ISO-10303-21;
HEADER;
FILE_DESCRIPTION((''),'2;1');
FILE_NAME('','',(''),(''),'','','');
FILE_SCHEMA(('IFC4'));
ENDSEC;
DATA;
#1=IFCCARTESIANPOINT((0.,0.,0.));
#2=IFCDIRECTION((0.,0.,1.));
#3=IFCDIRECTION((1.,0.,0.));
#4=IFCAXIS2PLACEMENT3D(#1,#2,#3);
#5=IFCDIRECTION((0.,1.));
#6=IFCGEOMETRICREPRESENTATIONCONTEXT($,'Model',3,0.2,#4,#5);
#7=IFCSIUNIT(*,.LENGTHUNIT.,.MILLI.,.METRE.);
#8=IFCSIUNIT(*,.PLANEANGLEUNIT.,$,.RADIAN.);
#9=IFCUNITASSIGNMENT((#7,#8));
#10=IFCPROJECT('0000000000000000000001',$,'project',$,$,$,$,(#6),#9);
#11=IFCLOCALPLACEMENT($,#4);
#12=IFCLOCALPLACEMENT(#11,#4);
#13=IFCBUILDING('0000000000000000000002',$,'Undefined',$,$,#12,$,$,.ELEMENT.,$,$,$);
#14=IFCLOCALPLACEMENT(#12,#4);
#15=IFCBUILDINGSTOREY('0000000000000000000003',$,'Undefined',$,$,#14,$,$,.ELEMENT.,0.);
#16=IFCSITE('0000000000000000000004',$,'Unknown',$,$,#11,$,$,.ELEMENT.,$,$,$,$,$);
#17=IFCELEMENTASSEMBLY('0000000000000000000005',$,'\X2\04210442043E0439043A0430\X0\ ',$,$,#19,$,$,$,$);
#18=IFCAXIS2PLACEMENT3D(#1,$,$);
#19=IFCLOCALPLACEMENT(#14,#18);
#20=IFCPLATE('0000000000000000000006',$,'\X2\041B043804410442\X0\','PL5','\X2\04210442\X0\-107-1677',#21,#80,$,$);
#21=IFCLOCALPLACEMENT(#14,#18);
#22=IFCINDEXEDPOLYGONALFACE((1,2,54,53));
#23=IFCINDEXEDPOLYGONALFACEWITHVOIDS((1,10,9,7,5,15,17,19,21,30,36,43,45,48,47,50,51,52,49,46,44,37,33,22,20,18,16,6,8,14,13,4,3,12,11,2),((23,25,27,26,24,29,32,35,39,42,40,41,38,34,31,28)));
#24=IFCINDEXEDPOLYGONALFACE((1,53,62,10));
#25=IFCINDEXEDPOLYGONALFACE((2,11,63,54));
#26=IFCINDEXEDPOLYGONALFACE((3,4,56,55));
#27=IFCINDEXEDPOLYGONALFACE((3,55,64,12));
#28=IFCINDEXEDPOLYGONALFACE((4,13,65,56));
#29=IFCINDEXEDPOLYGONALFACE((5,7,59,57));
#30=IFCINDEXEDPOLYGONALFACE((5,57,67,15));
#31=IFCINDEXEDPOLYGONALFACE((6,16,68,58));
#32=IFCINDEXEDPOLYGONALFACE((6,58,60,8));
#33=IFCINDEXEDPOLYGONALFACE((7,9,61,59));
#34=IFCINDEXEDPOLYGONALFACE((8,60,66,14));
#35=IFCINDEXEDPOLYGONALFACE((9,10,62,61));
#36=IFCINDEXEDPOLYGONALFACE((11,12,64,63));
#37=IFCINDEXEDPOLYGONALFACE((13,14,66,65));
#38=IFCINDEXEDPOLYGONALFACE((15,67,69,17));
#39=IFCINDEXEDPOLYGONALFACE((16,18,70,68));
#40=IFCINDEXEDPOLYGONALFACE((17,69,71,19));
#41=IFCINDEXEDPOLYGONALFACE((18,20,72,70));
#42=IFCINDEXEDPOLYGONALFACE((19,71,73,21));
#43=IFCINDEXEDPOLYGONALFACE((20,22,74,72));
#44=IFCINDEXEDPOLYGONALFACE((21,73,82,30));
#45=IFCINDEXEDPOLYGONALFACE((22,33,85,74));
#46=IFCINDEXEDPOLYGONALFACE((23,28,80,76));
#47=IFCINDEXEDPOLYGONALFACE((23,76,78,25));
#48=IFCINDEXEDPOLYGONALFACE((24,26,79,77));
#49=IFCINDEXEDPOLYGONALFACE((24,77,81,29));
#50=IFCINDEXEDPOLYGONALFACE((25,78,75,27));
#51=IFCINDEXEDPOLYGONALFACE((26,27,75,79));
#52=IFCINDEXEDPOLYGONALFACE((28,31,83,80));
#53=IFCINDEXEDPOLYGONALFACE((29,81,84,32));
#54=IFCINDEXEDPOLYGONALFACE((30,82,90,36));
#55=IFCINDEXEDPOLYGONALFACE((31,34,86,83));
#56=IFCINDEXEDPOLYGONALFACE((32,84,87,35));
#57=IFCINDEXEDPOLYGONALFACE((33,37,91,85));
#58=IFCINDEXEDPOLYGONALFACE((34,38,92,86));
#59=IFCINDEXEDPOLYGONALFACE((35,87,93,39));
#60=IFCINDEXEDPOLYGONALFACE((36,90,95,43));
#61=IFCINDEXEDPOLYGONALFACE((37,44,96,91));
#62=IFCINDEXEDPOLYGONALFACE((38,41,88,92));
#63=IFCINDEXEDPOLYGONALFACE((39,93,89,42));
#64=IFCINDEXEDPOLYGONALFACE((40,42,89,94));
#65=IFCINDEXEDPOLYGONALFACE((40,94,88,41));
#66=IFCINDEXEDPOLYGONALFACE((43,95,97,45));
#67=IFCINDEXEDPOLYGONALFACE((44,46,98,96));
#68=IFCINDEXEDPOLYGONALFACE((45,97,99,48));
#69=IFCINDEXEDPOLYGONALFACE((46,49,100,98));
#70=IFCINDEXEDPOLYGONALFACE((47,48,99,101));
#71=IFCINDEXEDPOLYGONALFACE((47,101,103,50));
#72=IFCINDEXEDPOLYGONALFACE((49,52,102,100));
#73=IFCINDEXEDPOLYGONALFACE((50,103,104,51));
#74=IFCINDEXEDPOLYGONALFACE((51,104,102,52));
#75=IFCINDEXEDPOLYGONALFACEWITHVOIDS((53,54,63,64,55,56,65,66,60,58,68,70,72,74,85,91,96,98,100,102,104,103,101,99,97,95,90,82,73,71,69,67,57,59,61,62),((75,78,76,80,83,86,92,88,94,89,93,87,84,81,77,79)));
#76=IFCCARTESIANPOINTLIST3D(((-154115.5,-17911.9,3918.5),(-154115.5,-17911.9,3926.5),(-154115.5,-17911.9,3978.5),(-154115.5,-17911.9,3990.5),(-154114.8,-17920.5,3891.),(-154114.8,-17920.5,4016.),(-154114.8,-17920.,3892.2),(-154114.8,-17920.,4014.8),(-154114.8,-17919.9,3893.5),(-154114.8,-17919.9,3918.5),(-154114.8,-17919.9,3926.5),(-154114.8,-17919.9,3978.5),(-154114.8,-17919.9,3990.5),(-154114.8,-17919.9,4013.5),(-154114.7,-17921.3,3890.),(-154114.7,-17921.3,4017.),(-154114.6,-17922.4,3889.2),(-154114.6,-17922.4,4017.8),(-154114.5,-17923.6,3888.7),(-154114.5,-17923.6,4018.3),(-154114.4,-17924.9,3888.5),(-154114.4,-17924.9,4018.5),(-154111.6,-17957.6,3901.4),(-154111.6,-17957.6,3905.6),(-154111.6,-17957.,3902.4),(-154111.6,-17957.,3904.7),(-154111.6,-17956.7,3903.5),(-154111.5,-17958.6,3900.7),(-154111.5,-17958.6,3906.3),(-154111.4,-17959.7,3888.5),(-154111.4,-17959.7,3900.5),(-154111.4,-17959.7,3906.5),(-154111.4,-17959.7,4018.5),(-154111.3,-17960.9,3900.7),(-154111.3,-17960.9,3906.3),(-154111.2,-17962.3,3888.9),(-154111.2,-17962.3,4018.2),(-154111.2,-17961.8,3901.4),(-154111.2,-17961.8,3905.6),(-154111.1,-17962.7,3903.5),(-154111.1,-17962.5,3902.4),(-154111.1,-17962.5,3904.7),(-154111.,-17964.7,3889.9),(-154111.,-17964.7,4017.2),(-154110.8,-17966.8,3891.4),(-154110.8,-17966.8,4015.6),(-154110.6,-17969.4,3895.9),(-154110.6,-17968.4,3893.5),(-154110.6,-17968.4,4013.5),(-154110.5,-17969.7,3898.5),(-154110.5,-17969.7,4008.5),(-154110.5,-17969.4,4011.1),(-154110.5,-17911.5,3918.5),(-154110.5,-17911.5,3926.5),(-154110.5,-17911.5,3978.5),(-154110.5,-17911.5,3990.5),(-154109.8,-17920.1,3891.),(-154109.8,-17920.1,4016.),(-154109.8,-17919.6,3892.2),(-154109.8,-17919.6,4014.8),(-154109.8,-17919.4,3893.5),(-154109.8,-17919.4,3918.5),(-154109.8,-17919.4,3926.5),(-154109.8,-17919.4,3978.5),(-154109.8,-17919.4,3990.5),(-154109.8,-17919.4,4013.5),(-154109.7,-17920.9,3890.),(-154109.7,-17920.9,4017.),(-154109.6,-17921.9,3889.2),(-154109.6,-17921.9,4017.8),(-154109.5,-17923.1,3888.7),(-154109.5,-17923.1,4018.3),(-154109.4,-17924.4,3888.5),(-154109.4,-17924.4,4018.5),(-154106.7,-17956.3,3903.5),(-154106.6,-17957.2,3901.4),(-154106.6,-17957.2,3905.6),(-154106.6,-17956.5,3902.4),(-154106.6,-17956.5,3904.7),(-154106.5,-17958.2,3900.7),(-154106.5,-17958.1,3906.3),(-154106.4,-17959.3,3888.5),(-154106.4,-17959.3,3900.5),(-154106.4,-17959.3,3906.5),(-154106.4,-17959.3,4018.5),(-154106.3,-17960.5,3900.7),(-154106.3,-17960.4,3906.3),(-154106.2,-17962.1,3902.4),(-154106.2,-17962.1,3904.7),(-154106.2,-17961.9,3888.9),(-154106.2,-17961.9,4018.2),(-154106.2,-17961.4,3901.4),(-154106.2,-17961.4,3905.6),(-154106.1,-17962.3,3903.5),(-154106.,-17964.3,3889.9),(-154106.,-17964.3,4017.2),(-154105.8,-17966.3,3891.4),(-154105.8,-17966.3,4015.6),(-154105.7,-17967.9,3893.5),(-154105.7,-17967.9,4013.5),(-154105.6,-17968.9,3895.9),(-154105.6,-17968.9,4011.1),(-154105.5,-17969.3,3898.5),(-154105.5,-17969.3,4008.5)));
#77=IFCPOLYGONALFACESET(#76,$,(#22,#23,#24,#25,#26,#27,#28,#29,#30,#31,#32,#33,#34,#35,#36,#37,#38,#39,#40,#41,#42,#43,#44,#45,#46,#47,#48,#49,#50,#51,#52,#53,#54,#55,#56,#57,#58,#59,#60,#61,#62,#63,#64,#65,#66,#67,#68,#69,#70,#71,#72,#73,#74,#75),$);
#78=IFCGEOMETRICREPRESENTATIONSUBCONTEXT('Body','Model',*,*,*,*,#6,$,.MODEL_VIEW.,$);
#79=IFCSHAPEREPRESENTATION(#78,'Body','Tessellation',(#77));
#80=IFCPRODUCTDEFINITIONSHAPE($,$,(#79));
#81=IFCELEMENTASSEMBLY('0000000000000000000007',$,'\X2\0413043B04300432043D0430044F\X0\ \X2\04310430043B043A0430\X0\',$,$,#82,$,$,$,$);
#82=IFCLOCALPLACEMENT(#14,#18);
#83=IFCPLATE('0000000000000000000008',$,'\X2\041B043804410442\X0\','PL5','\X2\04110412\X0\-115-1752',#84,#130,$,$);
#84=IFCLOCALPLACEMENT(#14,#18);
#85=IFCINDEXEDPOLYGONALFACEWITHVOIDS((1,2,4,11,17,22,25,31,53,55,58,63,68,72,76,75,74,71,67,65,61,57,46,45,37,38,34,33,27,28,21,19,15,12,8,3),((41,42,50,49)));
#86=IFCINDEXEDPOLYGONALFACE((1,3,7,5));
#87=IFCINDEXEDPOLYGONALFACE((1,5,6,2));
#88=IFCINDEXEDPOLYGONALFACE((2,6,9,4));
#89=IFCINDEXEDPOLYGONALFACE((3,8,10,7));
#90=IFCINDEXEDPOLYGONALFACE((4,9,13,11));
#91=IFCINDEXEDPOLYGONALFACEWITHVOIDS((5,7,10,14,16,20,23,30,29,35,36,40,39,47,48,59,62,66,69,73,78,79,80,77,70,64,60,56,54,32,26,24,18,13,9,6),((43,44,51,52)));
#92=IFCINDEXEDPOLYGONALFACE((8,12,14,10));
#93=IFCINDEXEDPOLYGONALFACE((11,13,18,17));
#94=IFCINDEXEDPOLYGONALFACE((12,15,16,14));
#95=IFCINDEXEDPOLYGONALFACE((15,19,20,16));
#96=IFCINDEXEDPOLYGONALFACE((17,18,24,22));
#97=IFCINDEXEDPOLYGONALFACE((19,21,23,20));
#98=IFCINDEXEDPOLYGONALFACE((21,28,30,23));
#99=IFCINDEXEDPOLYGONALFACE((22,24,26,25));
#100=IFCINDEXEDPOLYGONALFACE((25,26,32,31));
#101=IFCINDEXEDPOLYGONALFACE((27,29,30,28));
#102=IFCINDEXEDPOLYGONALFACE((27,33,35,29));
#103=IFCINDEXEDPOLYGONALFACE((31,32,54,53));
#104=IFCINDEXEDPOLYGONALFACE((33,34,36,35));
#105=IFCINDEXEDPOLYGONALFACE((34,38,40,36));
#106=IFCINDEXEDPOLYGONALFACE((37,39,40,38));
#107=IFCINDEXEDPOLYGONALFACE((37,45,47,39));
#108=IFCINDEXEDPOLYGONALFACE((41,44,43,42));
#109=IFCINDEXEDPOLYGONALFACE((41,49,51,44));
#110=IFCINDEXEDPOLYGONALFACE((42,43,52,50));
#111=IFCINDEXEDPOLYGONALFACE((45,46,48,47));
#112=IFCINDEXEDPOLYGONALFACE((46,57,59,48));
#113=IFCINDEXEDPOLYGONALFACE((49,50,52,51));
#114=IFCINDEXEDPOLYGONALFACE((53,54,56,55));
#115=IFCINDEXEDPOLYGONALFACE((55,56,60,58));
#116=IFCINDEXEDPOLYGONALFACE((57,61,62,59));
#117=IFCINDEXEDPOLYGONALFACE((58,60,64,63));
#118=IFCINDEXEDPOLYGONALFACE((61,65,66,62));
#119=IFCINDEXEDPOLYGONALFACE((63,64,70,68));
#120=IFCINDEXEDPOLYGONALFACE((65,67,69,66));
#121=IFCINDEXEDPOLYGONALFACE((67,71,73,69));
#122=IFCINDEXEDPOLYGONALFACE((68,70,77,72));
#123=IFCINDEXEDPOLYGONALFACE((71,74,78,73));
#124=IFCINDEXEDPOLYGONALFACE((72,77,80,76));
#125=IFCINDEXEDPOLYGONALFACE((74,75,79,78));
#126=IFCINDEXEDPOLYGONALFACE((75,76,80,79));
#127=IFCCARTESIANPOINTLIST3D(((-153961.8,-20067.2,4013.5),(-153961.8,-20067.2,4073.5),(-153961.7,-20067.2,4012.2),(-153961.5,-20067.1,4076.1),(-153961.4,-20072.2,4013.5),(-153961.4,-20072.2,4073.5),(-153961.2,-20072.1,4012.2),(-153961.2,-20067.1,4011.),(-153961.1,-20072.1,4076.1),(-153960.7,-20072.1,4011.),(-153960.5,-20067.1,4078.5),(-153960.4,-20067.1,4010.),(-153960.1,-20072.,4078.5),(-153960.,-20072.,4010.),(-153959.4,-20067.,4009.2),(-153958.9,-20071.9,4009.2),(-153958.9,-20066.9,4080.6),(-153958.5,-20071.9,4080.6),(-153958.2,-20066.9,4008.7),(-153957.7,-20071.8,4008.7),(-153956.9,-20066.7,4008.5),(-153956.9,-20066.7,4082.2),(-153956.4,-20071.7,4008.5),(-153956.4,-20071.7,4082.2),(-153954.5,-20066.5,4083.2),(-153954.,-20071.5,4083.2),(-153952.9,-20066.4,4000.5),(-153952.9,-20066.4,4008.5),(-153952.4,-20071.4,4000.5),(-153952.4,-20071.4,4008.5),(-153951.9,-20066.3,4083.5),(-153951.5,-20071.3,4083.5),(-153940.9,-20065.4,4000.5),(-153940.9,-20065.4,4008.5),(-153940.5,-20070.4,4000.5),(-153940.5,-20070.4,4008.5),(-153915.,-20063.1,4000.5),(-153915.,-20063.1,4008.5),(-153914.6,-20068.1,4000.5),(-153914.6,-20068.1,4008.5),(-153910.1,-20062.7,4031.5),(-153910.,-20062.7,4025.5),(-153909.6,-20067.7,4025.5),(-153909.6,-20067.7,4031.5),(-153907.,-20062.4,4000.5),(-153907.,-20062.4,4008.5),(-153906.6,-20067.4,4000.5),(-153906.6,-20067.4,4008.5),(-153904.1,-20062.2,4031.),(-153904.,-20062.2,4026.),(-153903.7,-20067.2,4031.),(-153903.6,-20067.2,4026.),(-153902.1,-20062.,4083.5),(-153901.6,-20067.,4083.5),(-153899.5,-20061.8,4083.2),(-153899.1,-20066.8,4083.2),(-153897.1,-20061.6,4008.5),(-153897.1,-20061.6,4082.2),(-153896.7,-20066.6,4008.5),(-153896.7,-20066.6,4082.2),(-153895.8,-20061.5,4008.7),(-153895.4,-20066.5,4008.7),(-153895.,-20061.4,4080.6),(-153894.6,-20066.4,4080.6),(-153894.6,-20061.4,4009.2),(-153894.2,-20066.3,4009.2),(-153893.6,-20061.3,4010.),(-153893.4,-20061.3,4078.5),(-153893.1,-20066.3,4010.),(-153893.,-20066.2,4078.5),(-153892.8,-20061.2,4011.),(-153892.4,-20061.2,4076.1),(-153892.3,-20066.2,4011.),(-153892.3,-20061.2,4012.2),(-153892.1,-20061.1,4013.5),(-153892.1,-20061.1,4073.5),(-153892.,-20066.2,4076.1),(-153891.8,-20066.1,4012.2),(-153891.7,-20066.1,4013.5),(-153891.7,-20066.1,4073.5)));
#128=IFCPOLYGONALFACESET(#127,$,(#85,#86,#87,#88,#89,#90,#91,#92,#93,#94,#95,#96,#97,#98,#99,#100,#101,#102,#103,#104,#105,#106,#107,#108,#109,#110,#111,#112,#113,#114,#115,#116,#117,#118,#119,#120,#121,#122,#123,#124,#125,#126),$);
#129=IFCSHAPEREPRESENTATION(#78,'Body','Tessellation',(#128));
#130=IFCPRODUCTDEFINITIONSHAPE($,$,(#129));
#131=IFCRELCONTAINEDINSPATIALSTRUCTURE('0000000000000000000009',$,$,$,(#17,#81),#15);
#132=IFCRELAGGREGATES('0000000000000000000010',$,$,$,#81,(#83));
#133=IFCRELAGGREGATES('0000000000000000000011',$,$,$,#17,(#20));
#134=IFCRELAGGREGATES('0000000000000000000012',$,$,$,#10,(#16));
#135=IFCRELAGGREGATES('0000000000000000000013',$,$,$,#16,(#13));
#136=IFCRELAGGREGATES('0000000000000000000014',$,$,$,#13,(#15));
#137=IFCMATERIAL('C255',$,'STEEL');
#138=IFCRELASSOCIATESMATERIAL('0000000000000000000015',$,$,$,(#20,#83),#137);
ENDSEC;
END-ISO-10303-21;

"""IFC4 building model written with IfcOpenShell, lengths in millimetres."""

from ifc_helpers import new_model, si_unit, direction, frame, origin_with_axes, place, context, subcontext, project, spatial, line, arc, indexed_curve, outline, extrude, material, element, aggregate, save


model = new_model("IFC4")

# Units and contexts
model_context = context("Model", 3, precision=0.2, world=origin_with_axes(), true_north=direction((0.0, 1.0)))
body_context = subcontext(model_context, "Body", "Model", "MODEL_VIEW")
ifc_project = project(units=[si_unit("LENGTHUNIT", "METRE", prefix="MILLI"), si_unit("PLANEANGLEUNIT", "RADIAN")], contexts=[model_context])

# Site, building, storey
site_placement = place(None, origin_with_axes())
site = spatial("IfcSite", under=ifc_project, at=site_placement, Name="Unknown", CompositionType="ELEMENT")
building_placement = place(site_placement, origin_with_axes())
building = spatial("IfcBuilding", under=site, at=building_placement, Name="Undefined", CompositionType="ELEMENT")
storey_placement = place(building_placement, origin_with_axes())
storey = spatial("IfcBuildingStorey", under=building, at=storey_placement, Name="Undefined", CompositionType="ELEMENT", Elevation=0.0)

# Shared definitions
ifc_material_1 = material(Name="C255", Category="STEEL")

# Element assemblies, plates, voiding features
assembly_1_placement = place(storey_placement, frame((-154120.8, -17880.2, 4823.9), z_axis=(0.086114, -0.996285, 0.0), x_axis=(0.0, 0.0, -1.0)))
assembly_1 = element("IfcElementAssembly", 1, at=assembly_1_placement, inside=storey, Name="Стойка ")
plate_1_placement = place(assembly_1_placement, frame((935.3, 5.0, 90.0), z_axis=(-0.000024, -1.0, 0.0), x_axis=(-1.0, 0.000024, 0.0)))
plate_1 = element("IfcPlate", 2, at=plate_1_placement, material=ifc_material_1, Name="Лист", Description="PL5", ObjectType="Ст-107-1677", context=body_context, shape_type="SolidModel", body=[
    extrude(outline(indexed_curve([(0.0, 10.0), (2.9, 2.9), (10.0, 0.0), (120.0, 0.0), (127.1, 2.9), (130.0, 10.0), (130.0, 45.0), (128.5, 48.5), (125.0, 50.0), (102.0, 50.0), (102.0, 58.0), (90.0, 58.0), (90.0, 50.0), (38.0, 50.0), (38.0, 58.0), (30.0, 58.0), (30.0, 50.0), (5.0, 50.0), (1.5, 48.5), (0.0, 45.0)], segments=[arc(1, 2, 3), line(3, 4), arc(4, 5, 6), line(6, 7), arc(7, 8, 9), line(9, 10, 11, 12, 13, 14, 15, 16, 17, 18), arc(18, 19, 20), line(20, 1)])), frame((0.0, 0.0, 2.5), z_axis=(0.0, 0.0, 1.0), x_axis=(1.0, 0.0, 0.0)), (0.0, 0.0, -1.0), 5.0),
])
voiding_feature_1_placement = place(plate_1_placement, frame((15.0, 10.0, 10.0), z_axis=(0.003022, -0.999995, 0.0), x_axis=(0.0, 0.0, -1.0)))
element("IfcVoidingFeature", 3, at=voiding_feature_1_placement, cuts=plate_1, Name="Балка", ObjectType="(?)", PredefinedType="HOLE", context=body_context, shape_type="SolidModel", body=[
    extrude(outline(indexed_curve([(3.0, 0.0), (2.8, 1.1), (2.1, 2.1), (1.1, 2.8), (0.0, 3.0), (-1.1, 2.8), (-2.1, 2.1), (-2.8, 1.1), (-3.0, 0.0), (-2.8, -1.1), (-2.1, -2.1), (-1.1, -2.8), (0.0, -3.0), (1.1, -2.8), (2.1, -2.1), (2.8, -1.1)], segments=[line(1, 2, 3, 4, 5, 6, 7, 8, 9, 10, 11, 12, 13, 14, 15, 16, 1)])), frame((0.0, 0.0, 0.0), z_axis=(-1.0, 0.0, 0.0), x_axis=(0.0, 0.0, 1.0)), (0.0, 0.0, -1.0), 20.0),
])
assembly_2_placement = place(storey_placement, frame((-154120.8, -17880.2, 3948.5), z_axis=(-0.996285, -0.086114, 0.000024), x_axis=(0.086114, -0.996285, 0.0)))
assembly_2 = element("IfcElementAssembly", 4, at=assembly_2_placement, inside=storey, Name="Главная балка")
plate_2_placement = place(assembly_2_placement, frame((2195.0, 135.0, -40.0), z_axis=(1.0, 0.000054, 0.0), x_axis=(0.0, -0.000054, 1.0)))
plate_2 = element("IfcPlate", 5, at=plate_2_placement, material=ifc_material_1, Name="Лист", Description="PL5", ObjectType="БВ-115-1752", context=body_context, shape_type="SolidModel", body=[
    extrude(outline(indexed_curve([(0.0, 10.0), (2.9, 2.9), (10.0, 0.0), (60.0, 0.0), (67.1, 2.9), (70.0, 10.0), (70.0, 70.0), (68.5, 73.5), (65.0, 75.0), (61.0, 75.0), (61.0, 83.0), (49.0, 83.0), (49.0, 75.0), (23.0, 75.0), (23.0, 83.0), (15.0, 83.0), (15.0, 75.0), (5.0, 75.0), (1.5, 73.5), (0.0, 70.0)], segments=[arc(1, 2, 3), line(3, 4), arc(4, 5, 6), line(6, 7), arc(7, 8, 9), line(9, 10, 11, 12, 13, 14, 15, 16, 17, 18), arc(18, 19, 20), line(20, 1)])), frame((0.0, 0.0, 2.5), z_axis=(0.0, 0.0, 1.0), x_axis=(1.0, 0.0, 0.0)), (0.0, 0.0, -1.0), 5.0),
])
voiding_feature_2_placement = place(plate_2_placement, frame((15.0, 55.0, 10.0), z_axis=(0.007997, -0.999968, -0.000026), x_axis=(0.0, 0.000026, -1.0)))
element("IfcVoidingFeature", 6, at=voiding_feature_2_placement, cuts=plate_2, Name="Балка", ObjectType="(?)", PredefinedType="HOLE", context=body_context, shape_type="SolidModel", body=[
    extrude(outline(indexed_curve([(2.5, -3.0), (3.0, 3.0), (-3.0, 3.0), (-2.5, -3.0)], segments=[line(1, 2, 3, 4, 1)])), frame((0.0, 0.0, 0.0), z_axis=(-1.0, 0.0, 0.0), x_axis=(0.0, 0.0, 1.0)), (0.0, 0.0, -1.0), 20.0),
])

aggregate(assembly_2, [plate_2])
aggregate(assembly_1, [plate_1])

save(model, "model.ifc")
